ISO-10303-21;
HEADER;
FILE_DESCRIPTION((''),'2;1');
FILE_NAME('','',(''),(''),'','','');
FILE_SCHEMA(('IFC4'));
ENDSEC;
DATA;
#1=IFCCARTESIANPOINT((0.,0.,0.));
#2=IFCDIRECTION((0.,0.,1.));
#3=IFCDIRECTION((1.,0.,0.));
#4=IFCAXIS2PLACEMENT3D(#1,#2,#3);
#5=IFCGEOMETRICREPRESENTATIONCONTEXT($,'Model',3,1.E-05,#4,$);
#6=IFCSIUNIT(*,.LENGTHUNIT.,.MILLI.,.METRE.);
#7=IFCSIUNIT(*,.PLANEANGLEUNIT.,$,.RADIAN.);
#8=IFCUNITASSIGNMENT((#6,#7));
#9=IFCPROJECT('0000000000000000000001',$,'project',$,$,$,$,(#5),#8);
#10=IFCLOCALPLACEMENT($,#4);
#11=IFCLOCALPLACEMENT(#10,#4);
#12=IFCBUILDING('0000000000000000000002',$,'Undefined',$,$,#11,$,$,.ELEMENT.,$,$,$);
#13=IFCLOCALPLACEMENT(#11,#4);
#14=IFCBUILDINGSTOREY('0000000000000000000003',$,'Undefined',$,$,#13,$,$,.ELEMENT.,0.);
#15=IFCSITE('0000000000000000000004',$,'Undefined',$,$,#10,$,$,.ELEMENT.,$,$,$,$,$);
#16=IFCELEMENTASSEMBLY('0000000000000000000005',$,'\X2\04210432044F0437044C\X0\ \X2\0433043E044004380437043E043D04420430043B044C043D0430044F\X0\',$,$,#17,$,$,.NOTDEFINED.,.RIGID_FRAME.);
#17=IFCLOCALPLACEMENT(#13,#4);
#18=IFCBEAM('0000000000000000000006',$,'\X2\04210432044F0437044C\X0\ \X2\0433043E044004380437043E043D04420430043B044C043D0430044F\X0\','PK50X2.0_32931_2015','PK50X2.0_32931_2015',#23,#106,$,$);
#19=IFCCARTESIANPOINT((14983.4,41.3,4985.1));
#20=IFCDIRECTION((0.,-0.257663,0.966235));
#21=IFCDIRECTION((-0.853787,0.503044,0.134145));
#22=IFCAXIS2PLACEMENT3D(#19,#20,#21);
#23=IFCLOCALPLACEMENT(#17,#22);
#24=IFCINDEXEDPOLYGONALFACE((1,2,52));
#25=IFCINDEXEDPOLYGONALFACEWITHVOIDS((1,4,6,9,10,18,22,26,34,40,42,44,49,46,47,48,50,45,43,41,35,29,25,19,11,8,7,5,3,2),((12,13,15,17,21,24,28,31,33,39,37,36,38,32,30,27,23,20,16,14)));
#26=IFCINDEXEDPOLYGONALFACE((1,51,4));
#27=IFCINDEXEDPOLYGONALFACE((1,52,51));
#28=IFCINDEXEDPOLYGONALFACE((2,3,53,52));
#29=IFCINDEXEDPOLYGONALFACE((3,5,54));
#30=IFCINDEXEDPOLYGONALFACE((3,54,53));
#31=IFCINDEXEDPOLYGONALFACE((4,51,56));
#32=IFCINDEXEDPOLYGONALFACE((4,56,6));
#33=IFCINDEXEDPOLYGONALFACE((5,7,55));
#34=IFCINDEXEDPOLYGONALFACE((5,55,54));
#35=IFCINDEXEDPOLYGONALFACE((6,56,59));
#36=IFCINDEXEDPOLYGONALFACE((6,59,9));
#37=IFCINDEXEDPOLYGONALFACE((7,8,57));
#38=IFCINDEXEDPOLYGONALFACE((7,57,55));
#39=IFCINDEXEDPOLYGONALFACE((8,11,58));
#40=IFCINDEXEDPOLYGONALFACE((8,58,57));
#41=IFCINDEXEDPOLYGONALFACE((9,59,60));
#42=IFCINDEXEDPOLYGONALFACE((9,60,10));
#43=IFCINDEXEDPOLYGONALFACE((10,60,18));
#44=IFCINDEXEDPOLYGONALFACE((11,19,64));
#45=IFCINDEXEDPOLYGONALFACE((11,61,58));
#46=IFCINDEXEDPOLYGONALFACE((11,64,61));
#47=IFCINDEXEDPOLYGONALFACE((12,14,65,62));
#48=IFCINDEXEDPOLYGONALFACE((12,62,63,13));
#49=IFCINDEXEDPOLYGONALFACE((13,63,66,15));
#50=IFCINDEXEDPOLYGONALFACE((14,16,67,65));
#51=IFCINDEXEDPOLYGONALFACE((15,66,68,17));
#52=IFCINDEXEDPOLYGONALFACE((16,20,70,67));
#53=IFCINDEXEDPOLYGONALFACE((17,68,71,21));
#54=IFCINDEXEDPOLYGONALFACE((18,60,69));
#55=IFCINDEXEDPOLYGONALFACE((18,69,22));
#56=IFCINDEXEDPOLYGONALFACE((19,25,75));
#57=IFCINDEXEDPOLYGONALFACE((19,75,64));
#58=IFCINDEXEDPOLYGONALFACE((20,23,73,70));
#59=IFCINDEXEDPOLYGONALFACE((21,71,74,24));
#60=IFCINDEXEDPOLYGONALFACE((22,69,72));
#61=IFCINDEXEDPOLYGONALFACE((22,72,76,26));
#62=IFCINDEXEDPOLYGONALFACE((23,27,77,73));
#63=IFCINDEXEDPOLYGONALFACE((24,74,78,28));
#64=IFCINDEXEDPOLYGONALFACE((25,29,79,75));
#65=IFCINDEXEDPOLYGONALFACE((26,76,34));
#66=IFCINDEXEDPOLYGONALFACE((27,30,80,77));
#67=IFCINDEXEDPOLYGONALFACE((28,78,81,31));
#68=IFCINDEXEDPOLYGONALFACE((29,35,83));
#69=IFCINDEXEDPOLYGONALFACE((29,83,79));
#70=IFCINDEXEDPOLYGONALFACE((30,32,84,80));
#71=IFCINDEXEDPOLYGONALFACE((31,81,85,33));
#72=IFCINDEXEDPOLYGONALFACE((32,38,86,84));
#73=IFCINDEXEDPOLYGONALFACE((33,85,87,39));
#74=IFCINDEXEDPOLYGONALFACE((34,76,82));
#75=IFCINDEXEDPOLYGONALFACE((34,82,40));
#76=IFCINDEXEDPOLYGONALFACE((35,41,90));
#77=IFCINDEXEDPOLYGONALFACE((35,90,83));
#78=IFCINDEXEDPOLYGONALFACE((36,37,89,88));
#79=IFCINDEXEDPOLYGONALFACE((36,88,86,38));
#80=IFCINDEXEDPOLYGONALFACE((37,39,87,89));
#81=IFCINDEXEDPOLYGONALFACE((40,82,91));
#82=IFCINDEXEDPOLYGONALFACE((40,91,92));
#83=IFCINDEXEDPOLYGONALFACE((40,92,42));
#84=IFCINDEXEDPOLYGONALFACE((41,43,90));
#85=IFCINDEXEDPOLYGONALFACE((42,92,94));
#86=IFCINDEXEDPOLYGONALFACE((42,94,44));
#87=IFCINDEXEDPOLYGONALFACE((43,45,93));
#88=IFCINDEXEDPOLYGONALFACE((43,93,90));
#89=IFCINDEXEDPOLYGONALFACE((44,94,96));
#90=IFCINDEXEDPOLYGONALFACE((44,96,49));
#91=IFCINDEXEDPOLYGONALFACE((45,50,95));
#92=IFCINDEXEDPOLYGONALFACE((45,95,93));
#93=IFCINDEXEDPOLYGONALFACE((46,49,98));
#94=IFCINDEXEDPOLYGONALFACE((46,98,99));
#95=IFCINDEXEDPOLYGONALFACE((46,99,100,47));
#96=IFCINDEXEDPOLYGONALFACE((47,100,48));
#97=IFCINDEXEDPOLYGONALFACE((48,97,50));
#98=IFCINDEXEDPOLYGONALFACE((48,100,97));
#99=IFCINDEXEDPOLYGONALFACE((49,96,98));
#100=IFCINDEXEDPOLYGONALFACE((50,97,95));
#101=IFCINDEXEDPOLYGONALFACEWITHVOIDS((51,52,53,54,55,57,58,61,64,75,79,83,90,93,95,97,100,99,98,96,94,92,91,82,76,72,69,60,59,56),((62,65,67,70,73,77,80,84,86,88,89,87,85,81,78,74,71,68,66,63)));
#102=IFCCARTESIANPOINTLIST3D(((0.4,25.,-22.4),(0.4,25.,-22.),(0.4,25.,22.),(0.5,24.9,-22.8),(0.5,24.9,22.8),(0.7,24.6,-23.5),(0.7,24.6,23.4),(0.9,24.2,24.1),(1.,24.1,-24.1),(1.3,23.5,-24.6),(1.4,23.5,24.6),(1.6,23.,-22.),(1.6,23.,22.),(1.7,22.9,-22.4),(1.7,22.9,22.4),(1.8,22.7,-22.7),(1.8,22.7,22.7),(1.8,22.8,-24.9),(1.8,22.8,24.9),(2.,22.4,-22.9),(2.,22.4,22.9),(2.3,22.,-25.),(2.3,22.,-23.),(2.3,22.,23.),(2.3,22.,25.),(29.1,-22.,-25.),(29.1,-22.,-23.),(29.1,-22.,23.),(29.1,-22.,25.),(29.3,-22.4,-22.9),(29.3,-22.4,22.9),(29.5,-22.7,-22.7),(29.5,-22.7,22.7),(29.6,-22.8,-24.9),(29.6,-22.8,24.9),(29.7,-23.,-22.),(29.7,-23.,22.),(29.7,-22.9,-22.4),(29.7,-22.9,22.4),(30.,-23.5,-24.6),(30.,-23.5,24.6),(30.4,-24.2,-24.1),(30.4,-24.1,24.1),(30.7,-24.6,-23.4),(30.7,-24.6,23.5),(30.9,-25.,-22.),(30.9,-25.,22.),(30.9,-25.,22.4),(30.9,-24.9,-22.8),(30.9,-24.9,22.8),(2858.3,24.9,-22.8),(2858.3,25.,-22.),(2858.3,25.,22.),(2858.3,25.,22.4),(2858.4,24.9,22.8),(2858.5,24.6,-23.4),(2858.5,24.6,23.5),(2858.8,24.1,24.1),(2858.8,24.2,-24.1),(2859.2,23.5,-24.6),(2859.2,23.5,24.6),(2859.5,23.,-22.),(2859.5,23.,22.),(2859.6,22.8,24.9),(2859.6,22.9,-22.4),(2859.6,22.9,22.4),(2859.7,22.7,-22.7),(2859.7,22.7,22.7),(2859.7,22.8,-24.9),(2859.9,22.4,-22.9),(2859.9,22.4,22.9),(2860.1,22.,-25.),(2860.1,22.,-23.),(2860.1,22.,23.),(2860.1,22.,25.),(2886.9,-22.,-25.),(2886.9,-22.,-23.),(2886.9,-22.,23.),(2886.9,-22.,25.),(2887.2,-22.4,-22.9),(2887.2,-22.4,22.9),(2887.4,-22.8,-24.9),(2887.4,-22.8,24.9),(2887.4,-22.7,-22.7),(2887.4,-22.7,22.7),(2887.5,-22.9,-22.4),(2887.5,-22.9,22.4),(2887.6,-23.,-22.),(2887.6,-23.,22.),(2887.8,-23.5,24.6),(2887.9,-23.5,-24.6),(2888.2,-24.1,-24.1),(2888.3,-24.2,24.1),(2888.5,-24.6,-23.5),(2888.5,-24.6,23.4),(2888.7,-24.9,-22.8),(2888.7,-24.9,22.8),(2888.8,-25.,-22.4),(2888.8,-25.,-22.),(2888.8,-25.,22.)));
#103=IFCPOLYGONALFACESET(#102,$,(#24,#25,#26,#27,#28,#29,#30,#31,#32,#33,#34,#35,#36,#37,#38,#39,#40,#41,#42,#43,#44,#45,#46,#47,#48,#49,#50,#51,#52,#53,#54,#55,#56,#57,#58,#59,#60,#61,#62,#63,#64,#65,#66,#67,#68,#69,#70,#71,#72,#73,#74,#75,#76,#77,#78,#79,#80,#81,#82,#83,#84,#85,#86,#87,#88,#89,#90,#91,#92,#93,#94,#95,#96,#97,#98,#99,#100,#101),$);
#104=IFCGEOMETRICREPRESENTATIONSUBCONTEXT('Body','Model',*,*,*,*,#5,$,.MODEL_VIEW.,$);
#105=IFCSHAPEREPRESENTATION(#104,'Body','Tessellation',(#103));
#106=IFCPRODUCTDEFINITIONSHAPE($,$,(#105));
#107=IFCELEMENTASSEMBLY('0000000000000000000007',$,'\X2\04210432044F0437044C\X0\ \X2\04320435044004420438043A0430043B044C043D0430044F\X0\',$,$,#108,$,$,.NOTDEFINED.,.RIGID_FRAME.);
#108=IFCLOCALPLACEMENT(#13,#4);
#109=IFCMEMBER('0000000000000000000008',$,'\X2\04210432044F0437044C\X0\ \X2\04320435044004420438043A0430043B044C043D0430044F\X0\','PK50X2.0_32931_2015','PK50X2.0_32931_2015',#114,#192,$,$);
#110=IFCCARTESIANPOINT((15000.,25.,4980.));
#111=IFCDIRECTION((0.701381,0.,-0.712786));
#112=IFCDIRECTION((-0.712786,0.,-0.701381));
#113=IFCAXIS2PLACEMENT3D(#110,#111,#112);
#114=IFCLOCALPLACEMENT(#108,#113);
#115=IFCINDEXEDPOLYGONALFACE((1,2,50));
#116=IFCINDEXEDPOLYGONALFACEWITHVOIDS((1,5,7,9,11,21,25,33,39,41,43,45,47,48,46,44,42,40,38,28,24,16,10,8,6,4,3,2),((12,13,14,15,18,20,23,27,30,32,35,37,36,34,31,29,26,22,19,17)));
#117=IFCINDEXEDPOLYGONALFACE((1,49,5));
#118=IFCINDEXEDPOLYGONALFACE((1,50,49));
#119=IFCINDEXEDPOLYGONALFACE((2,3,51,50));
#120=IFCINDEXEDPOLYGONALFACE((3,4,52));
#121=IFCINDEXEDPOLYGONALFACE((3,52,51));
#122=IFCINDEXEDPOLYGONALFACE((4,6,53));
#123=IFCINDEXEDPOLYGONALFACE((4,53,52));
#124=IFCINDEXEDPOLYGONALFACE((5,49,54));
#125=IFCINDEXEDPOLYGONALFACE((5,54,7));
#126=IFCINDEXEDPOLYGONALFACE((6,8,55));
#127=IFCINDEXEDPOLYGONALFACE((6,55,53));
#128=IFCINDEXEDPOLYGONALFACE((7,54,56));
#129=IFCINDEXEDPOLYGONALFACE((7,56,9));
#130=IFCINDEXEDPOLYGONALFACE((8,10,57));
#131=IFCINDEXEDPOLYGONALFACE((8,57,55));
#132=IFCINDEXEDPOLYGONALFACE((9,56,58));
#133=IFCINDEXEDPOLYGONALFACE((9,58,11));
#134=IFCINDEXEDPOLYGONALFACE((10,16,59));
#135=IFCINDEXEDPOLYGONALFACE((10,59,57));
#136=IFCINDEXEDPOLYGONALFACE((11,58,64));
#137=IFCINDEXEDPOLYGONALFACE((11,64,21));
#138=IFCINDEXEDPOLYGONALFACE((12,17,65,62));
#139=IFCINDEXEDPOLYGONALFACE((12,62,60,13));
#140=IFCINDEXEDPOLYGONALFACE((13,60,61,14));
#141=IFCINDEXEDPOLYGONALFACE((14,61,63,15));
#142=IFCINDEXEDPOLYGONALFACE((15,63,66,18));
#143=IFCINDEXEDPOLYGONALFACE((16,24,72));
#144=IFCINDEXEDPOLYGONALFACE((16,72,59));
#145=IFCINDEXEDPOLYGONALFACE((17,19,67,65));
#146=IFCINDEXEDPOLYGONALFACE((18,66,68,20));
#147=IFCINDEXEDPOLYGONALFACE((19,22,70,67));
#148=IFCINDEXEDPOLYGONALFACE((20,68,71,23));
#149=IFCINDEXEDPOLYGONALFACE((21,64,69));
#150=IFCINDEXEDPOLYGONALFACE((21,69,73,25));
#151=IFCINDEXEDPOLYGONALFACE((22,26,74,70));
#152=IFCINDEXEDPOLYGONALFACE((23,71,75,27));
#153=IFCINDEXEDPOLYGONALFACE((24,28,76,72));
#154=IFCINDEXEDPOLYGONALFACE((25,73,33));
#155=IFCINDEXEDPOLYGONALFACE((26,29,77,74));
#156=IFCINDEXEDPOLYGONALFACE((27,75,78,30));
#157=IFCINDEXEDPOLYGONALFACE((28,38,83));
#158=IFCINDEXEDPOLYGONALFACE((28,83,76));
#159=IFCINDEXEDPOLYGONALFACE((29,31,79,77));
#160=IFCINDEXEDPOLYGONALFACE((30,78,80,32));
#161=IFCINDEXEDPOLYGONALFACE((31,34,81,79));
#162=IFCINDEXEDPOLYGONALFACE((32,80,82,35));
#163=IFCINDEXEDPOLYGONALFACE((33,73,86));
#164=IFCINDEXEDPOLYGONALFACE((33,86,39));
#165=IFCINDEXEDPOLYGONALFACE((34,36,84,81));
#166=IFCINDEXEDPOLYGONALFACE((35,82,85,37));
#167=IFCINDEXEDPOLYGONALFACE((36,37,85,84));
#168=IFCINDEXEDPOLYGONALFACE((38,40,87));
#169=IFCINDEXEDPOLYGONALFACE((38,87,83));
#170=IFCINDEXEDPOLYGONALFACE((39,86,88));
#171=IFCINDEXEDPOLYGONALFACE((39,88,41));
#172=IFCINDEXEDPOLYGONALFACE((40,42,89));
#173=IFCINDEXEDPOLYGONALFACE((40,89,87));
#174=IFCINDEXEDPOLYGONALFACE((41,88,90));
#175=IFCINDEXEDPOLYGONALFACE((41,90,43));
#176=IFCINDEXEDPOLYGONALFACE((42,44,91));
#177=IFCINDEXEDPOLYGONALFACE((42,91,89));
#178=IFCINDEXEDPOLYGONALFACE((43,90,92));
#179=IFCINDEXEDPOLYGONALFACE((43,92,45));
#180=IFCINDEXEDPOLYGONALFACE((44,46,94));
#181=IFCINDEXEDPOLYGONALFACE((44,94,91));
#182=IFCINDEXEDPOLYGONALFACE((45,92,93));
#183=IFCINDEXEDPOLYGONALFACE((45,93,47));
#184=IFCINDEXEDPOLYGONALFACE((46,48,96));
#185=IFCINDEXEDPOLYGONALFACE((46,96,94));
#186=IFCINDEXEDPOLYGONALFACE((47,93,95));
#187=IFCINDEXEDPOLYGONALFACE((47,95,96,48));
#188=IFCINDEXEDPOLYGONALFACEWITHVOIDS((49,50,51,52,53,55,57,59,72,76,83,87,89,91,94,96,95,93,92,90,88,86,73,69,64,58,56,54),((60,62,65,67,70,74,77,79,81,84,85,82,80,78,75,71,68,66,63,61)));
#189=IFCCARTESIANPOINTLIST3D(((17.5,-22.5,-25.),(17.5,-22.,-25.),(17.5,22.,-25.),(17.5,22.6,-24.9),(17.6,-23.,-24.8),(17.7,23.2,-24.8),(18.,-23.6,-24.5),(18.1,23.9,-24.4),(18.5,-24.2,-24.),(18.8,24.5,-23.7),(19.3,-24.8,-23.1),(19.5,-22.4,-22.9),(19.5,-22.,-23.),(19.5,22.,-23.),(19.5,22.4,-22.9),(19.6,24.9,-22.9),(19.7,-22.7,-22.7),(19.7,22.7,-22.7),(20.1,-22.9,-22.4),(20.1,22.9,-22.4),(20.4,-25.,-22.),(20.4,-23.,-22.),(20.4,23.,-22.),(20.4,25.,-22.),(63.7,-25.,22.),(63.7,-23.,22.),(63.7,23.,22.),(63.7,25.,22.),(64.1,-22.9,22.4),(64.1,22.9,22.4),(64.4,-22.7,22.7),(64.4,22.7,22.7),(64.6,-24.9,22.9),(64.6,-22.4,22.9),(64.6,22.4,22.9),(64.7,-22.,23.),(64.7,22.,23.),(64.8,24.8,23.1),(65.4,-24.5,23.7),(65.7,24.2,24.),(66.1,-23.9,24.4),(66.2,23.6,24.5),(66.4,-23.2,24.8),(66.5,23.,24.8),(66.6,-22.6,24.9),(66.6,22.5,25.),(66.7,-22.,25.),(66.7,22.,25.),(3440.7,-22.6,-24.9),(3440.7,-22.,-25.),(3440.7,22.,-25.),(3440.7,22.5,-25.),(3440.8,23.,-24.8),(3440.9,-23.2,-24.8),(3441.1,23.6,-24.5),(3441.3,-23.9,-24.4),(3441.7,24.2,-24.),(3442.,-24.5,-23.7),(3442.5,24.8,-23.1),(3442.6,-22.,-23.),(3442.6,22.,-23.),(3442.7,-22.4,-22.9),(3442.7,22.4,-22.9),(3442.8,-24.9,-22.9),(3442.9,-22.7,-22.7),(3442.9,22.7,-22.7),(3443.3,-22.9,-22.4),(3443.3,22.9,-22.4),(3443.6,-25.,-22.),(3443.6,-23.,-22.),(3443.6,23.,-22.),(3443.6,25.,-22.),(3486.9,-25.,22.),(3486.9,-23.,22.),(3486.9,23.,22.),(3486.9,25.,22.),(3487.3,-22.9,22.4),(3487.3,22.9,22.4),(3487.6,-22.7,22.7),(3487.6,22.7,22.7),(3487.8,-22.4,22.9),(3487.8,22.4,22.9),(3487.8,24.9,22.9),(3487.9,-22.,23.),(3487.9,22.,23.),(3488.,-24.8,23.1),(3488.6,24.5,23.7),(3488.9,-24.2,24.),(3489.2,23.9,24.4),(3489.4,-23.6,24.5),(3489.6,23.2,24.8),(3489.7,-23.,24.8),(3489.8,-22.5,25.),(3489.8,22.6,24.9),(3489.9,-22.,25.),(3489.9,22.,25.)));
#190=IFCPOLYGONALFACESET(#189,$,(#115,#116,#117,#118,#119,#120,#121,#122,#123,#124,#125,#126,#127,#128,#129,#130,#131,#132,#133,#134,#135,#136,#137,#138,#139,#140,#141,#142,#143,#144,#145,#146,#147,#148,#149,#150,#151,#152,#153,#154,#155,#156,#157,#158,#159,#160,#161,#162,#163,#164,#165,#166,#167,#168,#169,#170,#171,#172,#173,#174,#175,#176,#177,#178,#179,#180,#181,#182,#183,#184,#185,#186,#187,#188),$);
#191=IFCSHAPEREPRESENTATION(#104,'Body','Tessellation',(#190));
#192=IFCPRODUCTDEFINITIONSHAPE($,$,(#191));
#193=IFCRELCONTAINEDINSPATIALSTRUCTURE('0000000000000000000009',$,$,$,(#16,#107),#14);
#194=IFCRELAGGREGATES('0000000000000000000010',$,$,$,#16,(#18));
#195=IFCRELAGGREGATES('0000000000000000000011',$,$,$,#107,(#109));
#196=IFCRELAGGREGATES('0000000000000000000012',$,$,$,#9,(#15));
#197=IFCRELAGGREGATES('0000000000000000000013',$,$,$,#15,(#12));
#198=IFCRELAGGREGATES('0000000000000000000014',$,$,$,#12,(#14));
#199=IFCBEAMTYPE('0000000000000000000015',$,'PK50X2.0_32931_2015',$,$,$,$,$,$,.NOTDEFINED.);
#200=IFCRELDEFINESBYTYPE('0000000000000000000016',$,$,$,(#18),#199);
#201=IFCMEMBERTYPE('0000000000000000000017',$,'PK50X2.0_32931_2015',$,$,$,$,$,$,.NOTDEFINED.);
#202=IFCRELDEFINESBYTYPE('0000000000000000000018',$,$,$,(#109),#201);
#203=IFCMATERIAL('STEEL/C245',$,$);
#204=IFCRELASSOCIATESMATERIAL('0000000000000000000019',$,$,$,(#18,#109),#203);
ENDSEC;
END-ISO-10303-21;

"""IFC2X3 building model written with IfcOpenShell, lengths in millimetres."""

from ifc_helpers import new_model, si_unit, frame, origin_with_axes, origin_2d_with_axis, place, context, subcontext, project, spatial, hollow_rectangle, extrude, clip, halfspace, material, type_object, element, aggregate, save


model = new_model("IFC2X3")

# Units and contexts
model_context = context("Model", 3, precision=1e-05, world=origin_with_axes())
body_context = subcontext(model_context, "Body", "Model", "MODEL_VIEW")
ifc_project = project(units=[si_unit("LENGTHUNIT", "METRE", prefix="MILLI"), si_unit("PLANEANGLEUNIT", "RADIAN")], contexts=[model_context])

# Site, building, storey
site_placement = place(None, origin_with_axes())
site = spatial("IfcSite", under=ifc_project, at=site_placement, Name="Undefined", CompositionType="ELEMENT")
building_placement = place(site_placement, origin_with_axes())
building = spatial("IfcBuilding", under=site, at=building_placement, Name="Undefined", CompositionType="ELEMENT")
storey_placement = place(building_placement, origin_with_axes())
storey = spatial("IfcBuildingStorey", under=building, at=storey_placement, Name="Undefined", CompositionType="ELEMENT", Elevation=0.0)

# Shared definitions
ifc_material_1 = material(Name="STEEL/C245")

# Element assembly, beam
assembly_1_placement = place(storey_placement, origin_with_axes())
assembly_1 = element("IfcElementAssembly", 1, at=assembly_1_placement, inside=storey, Name="Связь горизонтальная", AssemblyPlace="NOTDEFINED", PredefinedType="RIGID_FRAME")
beam_type_1 = type_object("IfcBeamType", Name="PK50X2.0_32931_2015", PredefinedType="NOTDEFINED")
beam_1_placement = place(assembly_1_placement, frame((14983.4, 41.3, 4985.1), z_axis=(0.0, -0.257663, 0.966235), x_axis=(-0.853787, 0.503044, 0.134145)))
beam_1 = element("IfcBeam", 2, at=beam_1_placement, type_object=beam_type_1, material=ifc_material_1, Name="Связь горизонтальная", Description="PK50X2.0_32931_2015", ObjectType="PK50X2.0_32931_2015", context=body_context, shape_type="Clipping", body=[
    clip(clip(extrude(hollow_rectangle(XDim=50.0, YDim=50.0, WallThickness=2.0, InnerFilletRadius=1.0, OuterFilletRadius=3.0, at=origin_2d_with_axis()), frame((2917.4, 0.0, 0.0), z_axis=(-1.0, 0.0, 0.0), x_axis=(0.0, -1.0, 0.0)), (0.0, 0.0, 1.0), 2945.6), halfspace(frame((2920.7, -77.3, 25.0), z_axis=(-0.853787, -0.520623, 0.0), x_axis=(-0.520623, 0.853787, 0.0)), True)), halfspace(frame((48.4, -53.7, 25.0), z_axis=(0.853787, 0.520623, 0.0), x_axis=(0.520623, -0.853787, 0.0)), True)),
])
aggregate(assembly_1, [beam_1])

# Element assembly, member
assembly_2_placement = place(storey_placement, origin_with_axes())
assembly_2 = element("IfcElementAssembly", 3, at=assembly_2_placement, inside=storey, Name="Связь вертикальная", AssemblyPlace="NOTDEFINED", PredefinedType="RIGID_FRAME")
member_type_1 = type_object("IfcMemberType", Name="PK50X2.0_32931_2015", PredefinedType="NOTDEFINED")
member_1_placement = place(assembly_2_placement, frame((15000.0, 25.0, 4980.0), z_axis=(0.701381, 0.0, -0.712786), x_axis=(-0.712786, 0.0, -0.701381)))
member_1 = element("IfcMember", 4, at=member_1_placement, type_object=member_type_1, material=ifc_material_1, Name="Связь вертикальная", Description="PK50X2.0_32931_2015", ObjectType="PK50X2.0_32931_2015", context=body_context, shape_type="Clipping", body=[
    clip(clip(extrude(hollow_rectangle(XDim=50.0, YDim=50.0, WallThickness=2.0, InnerFilletRadius=1.0, OuterFilletRadius=3.0, at=origin_2d_with_axis()), frame((3515.0, 0.0, 0.0), z_axis=(-1.0, 0.0, 0.0), x_axis=(0.0, -1.0, 0.0)), (0.0, 0.0, 1.0), 3522.6), halfspace(frame((3446.9, -25.0, -18.6), z_axis=(-0.712786, 0.0, 0.701381), x_axis=(-0.701381, 0.0, -0.712786)), True)), halfspace(frame((87.1, -25.0, 45.7), z_axis=(0.712786, 0.0, -0.701381), x_axis=(0.701381, 0.0, 0.712786)), True)),
])
aggregate(assembly_2, [member_1])

save(model, "model.ifc")
